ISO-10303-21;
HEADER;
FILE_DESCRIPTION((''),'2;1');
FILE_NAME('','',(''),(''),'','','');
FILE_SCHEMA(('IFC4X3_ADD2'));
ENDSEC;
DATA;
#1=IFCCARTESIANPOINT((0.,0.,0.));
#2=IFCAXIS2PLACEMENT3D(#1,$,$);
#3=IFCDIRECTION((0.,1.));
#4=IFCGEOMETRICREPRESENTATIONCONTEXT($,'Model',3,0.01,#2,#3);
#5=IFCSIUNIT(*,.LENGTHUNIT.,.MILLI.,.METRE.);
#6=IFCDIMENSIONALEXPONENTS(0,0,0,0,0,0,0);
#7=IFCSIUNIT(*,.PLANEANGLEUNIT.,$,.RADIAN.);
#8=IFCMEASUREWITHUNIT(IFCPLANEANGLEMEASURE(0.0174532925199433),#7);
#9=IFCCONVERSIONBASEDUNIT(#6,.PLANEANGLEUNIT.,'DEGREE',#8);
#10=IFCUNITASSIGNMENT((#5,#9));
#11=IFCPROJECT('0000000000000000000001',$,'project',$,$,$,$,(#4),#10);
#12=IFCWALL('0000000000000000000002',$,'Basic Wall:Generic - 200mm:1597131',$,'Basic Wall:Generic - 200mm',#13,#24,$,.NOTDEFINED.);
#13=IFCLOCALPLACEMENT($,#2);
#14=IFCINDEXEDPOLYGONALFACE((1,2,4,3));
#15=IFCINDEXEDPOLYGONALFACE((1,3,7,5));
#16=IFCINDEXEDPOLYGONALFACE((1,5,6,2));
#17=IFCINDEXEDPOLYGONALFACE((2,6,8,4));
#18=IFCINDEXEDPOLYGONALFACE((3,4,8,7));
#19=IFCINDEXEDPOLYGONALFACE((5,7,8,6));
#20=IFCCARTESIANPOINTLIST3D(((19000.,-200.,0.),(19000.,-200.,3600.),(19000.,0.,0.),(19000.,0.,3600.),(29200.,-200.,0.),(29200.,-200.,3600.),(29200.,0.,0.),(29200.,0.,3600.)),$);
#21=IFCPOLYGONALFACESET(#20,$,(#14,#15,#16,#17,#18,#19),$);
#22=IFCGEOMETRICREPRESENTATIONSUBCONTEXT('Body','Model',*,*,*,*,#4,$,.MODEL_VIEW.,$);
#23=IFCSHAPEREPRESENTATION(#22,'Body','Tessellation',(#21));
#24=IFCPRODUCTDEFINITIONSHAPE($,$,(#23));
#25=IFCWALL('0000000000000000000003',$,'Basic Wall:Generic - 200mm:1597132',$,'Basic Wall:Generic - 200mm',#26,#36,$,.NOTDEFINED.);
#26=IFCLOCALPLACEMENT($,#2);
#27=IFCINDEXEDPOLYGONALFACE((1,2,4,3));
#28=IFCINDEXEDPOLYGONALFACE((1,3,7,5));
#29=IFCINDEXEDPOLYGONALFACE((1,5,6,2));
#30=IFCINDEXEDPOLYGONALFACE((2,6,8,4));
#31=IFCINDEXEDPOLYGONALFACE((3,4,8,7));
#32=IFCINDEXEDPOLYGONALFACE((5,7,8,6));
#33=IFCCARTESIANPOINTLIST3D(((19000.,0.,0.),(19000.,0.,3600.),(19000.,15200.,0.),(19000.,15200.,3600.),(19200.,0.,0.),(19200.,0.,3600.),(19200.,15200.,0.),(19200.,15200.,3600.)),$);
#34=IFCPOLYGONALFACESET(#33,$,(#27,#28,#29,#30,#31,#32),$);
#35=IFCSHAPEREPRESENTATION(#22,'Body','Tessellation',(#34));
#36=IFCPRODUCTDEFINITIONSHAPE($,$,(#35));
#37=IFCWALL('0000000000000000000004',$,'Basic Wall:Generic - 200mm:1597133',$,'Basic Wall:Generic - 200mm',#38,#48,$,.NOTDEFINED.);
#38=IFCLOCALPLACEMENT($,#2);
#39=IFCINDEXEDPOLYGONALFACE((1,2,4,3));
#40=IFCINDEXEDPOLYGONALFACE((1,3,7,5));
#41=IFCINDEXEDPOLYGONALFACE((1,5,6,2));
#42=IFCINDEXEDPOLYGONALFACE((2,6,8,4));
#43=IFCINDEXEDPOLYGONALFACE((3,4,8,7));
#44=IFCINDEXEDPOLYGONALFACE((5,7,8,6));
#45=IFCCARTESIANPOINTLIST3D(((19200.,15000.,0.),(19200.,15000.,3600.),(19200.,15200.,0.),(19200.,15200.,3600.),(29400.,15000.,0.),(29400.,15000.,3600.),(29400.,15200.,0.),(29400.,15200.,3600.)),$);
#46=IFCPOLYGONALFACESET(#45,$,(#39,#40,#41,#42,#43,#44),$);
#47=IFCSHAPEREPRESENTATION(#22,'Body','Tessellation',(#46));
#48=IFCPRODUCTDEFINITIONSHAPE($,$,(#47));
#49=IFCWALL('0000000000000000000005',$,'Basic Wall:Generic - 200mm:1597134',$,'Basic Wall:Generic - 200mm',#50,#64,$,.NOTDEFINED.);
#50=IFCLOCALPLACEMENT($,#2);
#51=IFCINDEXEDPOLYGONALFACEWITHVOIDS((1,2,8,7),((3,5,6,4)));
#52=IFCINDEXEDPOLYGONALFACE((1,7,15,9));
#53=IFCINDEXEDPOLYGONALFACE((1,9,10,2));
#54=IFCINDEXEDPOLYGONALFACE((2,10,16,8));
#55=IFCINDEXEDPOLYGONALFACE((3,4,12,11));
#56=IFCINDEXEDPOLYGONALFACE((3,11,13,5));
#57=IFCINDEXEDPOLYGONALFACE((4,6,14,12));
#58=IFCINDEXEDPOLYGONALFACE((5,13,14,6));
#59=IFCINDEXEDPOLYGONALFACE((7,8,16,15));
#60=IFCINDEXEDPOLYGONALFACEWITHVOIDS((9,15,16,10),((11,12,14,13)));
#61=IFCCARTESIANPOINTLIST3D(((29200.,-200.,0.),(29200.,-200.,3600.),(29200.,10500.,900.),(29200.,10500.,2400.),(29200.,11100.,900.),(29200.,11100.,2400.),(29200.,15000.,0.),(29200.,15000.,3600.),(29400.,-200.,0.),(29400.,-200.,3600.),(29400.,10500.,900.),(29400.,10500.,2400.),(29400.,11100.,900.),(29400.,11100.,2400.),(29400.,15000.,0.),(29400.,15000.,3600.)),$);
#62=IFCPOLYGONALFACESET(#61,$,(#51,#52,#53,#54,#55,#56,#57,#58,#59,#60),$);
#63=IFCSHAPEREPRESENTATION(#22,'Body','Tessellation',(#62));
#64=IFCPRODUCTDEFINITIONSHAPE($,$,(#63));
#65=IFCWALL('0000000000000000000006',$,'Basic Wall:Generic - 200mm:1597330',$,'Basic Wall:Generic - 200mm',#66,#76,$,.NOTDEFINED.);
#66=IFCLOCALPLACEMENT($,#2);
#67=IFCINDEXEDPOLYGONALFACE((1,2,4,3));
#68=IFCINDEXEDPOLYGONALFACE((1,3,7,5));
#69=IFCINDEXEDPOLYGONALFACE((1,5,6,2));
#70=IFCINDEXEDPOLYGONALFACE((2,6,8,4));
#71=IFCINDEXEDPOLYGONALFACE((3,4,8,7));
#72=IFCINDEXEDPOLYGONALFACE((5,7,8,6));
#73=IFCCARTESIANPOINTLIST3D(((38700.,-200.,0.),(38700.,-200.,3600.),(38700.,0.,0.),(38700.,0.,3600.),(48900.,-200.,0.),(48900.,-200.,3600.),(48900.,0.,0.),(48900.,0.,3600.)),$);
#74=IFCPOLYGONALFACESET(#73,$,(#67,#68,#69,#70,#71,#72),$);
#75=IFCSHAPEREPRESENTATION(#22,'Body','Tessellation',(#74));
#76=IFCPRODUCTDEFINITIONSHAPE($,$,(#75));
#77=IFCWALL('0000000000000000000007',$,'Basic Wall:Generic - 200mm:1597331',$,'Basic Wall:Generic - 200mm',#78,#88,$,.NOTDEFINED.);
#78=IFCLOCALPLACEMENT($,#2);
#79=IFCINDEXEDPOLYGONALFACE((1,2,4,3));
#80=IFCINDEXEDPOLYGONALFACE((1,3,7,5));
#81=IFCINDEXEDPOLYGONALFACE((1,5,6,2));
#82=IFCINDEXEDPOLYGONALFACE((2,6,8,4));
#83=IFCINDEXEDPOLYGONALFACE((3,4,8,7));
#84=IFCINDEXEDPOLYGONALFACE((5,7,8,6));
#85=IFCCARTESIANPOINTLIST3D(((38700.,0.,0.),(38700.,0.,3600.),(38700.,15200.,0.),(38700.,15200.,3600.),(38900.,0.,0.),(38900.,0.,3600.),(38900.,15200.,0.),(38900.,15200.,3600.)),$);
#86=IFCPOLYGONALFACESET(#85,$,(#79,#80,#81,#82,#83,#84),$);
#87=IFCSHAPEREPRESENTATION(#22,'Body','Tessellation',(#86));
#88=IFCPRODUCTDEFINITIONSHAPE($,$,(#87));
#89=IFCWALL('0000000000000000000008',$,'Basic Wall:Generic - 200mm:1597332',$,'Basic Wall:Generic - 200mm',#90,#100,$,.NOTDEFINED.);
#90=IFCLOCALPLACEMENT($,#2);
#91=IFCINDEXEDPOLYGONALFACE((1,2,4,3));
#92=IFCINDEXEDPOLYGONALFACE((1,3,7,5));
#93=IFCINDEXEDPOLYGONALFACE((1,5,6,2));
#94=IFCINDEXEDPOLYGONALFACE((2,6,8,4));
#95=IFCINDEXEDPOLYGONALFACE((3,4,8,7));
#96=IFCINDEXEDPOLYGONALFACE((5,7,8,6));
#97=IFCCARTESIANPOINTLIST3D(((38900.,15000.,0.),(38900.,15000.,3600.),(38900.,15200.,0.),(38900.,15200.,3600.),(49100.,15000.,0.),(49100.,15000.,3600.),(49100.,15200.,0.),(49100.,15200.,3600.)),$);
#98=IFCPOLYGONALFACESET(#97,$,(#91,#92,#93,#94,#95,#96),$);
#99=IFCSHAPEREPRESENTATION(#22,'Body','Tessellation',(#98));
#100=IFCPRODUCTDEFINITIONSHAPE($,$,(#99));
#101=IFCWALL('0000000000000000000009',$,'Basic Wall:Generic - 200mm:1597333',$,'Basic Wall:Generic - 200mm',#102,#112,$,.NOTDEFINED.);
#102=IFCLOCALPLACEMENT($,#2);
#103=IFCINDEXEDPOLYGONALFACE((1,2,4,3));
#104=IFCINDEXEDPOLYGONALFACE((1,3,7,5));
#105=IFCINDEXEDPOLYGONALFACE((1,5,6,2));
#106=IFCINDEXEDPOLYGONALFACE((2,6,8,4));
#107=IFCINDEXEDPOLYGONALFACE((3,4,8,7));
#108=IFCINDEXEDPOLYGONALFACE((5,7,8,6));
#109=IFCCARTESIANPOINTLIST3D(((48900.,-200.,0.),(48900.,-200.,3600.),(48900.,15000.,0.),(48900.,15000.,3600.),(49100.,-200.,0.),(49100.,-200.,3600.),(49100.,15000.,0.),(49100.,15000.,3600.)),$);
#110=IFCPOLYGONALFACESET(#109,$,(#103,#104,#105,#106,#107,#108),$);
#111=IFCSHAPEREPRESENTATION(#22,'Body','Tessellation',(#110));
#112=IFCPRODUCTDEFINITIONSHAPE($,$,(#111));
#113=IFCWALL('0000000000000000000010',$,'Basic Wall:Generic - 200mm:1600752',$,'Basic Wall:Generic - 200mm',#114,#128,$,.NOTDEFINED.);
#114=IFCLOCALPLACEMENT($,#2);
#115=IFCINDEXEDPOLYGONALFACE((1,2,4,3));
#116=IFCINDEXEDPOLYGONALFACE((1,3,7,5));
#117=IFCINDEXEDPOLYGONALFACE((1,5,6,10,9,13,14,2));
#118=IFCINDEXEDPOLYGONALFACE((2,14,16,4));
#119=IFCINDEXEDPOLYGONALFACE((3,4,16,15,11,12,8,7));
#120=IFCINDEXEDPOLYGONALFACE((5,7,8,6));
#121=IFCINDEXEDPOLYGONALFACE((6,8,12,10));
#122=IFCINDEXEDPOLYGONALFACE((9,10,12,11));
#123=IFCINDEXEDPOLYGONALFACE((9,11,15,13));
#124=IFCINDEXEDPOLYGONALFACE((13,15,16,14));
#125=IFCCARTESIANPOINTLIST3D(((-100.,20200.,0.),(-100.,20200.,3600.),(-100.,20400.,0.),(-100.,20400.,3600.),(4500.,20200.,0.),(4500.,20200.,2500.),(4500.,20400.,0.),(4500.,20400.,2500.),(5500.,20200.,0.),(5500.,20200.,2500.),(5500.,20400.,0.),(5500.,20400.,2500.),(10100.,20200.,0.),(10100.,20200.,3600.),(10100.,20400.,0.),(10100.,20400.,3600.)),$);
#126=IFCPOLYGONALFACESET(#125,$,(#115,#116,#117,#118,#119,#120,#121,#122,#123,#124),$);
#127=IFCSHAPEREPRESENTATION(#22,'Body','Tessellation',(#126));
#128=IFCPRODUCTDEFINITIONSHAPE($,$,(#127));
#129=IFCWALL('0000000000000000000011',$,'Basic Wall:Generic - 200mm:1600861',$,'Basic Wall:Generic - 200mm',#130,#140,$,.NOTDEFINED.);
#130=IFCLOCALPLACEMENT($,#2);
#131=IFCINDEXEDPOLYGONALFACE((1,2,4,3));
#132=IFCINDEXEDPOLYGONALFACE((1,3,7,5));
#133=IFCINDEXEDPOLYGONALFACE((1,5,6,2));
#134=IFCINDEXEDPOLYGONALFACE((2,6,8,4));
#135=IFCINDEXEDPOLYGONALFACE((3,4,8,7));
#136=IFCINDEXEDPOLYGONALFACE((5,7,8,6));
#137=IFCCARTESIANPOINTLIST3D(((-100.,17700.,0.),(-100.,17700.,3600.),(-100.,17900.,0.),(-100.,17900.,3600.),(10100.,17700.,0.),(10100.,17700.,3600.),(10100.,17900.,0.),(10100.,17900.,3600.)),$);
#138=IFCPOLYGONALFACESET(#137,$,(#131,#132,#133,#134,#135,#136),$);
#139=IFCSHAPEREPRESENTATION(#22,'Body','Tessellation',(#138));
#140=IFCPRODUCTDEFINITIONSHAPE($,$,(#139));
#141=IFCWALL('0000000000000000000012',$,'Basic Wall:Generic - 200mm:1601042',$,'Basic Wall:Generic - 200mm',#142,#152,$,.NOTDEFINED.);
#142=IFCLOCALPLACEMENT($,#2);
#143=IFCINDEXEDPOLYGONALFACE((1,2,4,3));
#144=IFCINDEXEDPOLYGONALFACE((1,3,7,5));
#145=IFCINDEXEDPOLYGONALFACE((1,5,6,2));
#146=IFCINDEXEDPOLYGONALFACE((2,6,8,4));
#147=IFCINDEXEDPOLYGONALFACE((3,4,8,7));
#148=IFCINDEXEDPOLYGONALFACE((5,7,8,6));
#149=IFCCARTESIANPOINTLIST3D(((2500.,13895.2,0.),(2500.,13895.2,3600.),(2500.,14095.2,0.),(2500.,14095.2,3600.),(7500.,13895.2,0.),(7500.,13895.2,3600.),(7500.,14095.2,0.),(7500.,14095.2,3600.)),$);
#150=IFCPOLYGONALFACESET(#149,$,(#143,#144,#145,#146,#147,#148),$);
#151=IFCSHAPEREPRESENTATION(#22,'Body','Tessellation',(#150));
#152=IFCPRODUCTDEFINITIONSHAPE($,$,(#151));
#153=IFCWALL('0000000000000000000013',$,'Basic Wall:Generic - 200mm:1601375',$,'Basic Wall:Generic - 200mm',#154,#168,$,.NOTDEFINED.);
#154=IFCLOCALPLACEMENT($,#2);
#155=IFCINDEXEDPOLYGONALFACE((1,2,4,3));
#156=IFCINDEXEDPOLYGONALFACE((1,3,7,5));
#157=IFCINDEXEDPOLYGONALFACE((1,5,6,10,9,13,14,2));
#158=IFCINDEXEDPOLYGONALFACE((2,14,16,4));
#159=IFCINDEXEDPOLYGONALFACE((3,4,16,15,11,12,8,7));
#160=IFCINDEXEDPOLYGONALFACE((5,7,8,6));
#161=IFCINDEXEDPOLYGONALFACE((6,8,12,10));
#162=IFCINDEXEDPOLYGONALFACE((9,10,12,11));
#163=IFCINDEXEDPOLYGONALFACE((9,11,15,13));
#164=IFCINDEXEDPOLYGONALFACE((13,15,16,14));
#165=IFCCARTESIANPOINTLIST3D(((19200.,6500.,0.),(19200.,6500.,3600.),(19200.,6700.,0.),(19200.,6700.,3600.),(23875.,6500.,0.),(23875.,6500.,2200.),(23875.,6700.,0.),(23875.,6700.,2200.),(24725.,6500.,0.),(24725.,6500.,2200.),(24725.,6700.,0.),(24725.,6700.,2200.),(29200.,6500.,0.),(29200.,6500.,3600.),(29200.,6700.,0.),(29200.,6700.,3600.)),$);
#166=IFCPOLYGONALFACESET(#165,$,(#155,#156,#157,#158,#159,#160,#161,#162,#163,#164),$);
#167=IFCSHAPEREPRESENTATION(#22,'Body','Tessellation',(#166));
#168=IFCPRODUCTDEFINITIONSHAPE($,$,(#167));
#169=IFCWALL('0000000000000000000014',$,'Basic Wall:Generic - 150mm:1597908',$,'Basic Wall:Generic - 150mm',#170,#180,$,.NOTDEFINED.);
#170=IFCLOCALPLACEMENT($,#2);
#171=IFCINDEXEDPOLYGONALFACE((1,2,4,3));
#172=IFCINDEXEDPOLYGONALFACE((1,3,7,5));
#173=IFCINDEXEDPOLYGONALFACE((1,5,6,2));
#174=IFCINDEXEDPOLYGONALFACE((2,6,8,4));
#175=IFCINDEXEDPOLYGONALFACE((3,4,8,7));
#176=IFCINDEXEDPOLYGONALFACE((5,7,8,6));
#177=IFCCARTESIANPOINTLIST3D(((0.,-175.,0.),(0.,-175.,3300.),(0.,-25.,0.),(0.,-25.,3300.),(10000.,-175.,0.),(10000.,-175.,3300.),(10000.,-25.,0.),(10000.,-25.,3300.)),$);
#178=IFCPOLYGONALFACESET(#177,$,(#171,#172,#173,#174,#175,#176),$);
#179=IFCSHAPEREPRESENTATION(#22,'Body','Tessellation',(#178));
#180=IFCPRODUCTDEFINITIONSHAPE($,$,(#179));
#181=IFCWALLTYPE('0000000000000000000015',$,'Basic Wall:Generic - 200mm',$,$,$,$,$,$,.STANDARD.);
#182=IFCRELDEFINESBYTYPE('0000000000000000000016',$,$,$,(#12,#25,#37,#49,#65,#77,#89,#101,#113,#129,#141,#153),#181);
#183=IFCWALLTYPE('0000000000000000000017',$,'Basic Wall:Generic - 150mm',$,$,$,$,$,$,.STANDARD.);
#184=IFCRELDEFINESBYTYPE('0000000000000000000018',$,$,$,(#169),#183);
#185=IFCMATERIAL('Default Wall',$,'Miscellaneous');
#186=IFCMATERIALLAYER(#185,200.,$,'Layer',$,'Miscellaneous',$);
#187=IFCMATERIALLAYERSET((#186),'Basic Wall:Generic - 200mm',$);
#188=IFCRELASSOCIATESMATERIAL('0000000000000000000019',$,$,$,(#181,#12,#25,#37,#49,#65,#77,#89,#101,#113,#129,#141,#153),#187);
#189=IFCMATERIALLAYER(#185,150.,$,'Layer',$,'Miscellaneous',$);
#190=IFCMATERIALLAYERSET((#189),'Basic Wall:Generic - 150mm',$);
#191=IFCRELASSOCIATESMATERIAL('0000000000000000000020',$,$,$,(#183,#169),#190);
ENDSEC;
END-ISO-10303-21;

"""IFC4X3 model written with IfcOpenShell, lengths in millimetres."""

from ifc_helpers import new_model, entity, si_unit, converted_unit, direction, frame, frame_2d, origin, origin_2d_with_axis, place, context, subcontext, project, rectangle, extrude, material, layer, layer_set, type_object, element, save


model = new_model("IFC4X3")

# Units and contexts
model_context = context("Model", 3, precision=0.01, world=origin(), true_north=direction((0.0, 1.0)))
body_context = subcontext(model_context, "Body", "Model", "MODEL_VIEW")
ifc_project = project(units=[si_unit("LENGTHUNIT", "METRE", prefix="MILLI"), converted_unit("PLANEANGLEUNIT", "DEGREE", entity("IfcPlaneAngleMeasure", 0.0174532925199433), si_unit("PLANEANGLEUNIT", "RADIAN"), dimensions=[0, 0, 0, 0, 0, 0, 0])], contexts=[model_context])

# Shared definitions
placement_1 = place(None, origin())
placement_2 = place(placement_1, origin())
placement_3 = place(placement_2, origin())

# Walls
ifc_material_1 = material(Name="Default Wall", Category="Miscellaneous")
ifc_layer_1 = layer(ifc_material_1, 200.0, Name="Layer", Category="Miscellaneous")
ifc_layer_set_1 = layer_set([ifc_layer_1], Name="Basic Wall:Generic - 200mm")
wall_type_1 = type_object("IfcWallType", Name="Basic Wall:Generic - 200mm", PredefinedType="STANDARD", material=ifc_layer_set_1)
wall_1_placement = place(placement_3, frame((19000.0, -100.0, 0.0)))
element("IfcWall", 1, at=wall_1_placement, type_object=wall_type_1, material=ifc_layer_set_1, Name="Basic Wall:Generic - 200mm:1597131", ObjectType="Basic Wall:Generic - 200mm", PredefinedType="NOTDEFINED", context=body_context, shape_type="SweptSolid", body=[
    extrude(rectangle(XDim=10200.0, YDim=200.0, at=frame_2d((5100.0, 0.0), x_axis=(-1.0, 0.0))), origin(), (0.0, 0.0, 1.0), 3600.0),
])
wall_2_placement = place(placement_3, frame((19100.0, 15200.0, 0.0), z_axis=(0.0, 0.0, 1.0), x_axis=(0.0, -1.0, 0.0)))
element("IfcWall", 2, at=wall_2_placement, type_object=wall_type_1, material=ifc_layer_set_1, Name="Basic Wall:Generic - 200mm:1597132", ObjectType="Basic Wall:Generic - 200mm", PredefinedType="NOTDEFINED", context=body_context, shape_type="SweptSolid", body=[
    extrude(rectangle(XDim=15200.0, YDim=200.0, at=frame_2d((7600.0, 0.0), x_axis=(-1.0, 0.0))), origin(), (0.0, 0.0, 1.0), 3600.0),
])
wall_3_placement = place(placement_3, frame((29400.0, 15100.0, 0.0), z_axis=(0.0, 0.0, 1.0), x_axis=(-1.0, 0.0, 0.0)))
element("IfcWall", 3, at=wall_3_placement, type_object=wall_type_1, material=ifc_layer_set_1, Name="Basic Wall:Generic - 200mm:1597133", ObjectType="Basic Wall:Generic - 200mm", PredefinedType="NOTDEFINED", context=body_context, shape_type="SweptSolid", body=[
    extrude(rectangle(XDim=10200.0, YDim=200.0, at=frame_2d((5100.0, 0.0), x_axis=(-1.0, 0.0))), origin(), (0.0, 0.0, 1.0), 3600.0),
])

# Wall, opening
wall_4_placement = place(placement_3, frame((29300.0, -200.0, 0.0), z_axis=(0.0, 0.0, 1.0), x_axis=(0.0, 1.0, 0.0)))
wall_4 = element("IfcWall", 4, at=wall_4_placement, type_object=wall_type_1, material=ifc_layer_set_1, Name="Basic Wall:Generic - 200mm:1597134", ObjectType="Basic Wall:Generic - 200mm", PredefinedType="NOTDEFINED", context=body_context, shape_type="SweptSolid", body=[
    extrude(rectangle(XDim=15200.0, YDim=200.0, at=frame_2d((7600.0, 0.0), x_axis=(-1.0, 0.0))), origin(), (0.0, 0.0, 1.0), 3600.0),
])
opening_1_placement = place(wall_4_placement, frame((11300.0, 100.0, 900.0)))
element("IfcOpeningElement", 5, at=opening_1_placement, cuts=wall_4, PredefinedType="OPENING", context=body_context, shape_type="SweptSolid", body=[
    extrude(rectangle(XDim=1500.0, YDim=600.0, at=frame_2d((750.0, 300.0), x_axis=(-1.0, 0.0))), frame((0.0, 0.0, 0.0), z_axis=(0.0, -1.0, 0.0), x_axis=(0.0, 0.0, 1.0)), (0.0, 0.0, 1.0), 200.0),
])

# Walls
wall_5_placement = place(placement_3, frame((38700.0, -100.0, 0.0)))
element("IfcWall", 6, at=wall_5_placement, type_object=wall_type_1, material=ifc_layer_set_1, Name="Basic Wall:Generic - 200mm:1597330", ObjectType="Basic Wall:Generic - 200mm", PredefinedType="NOTDEFINED", context=body_context, shape_type="SweptSolid", body=[
    extrude(rectangle(XDim=10200.0, YDim=200.0, at=frame_2d((5100.0, 0.0), x_axis=(-1.0, 0.0))), origin(), (0.0, 0.0, 1.0), 3600.0),
])
wall_6_placement = place(placement_3, frame((38800.0, 15200.0, 0.0), z_axis=(0.0, 0.0, 1.0), x_axis=(0.0, -1.0, 0.0)))
element("IfcWall", 7, at=wall_6_placement, type_object=wall_type_1, material=ifc_layer_set_1, Name="Basic Wall:Generic - 200mm:1597331", ObjectType="Basic Wall:Generic - 200mm", PredefinedType="NOTDEFINED", context=body_context, shape_type="SweptSolid", body=[
    extrude(rectangle(XDim=15200.0, YDim=200.0, at=frame_2d((7600.0, 0.0), x_axis=(-1.0, 0.0))), origin(), (0.0, 0.0, 1.0), 3600.0),
])
wall_7_placement = place(placement_3, frame((49100.0, 15100.0, 0.0), z_axis=(0.0, 0.0, 1.0), x_axis=(-1.0, 0.0, 0.0)))
element("IfcWall", 8, at=wall_7_placement, type_object=wall_type_1, material=ifc_layer_set_1, Name="Basic Wall:Generic - 200mm:1597332", ObjectType="Basic Wall:Generic - 200mm", PredefinedType="NOTDEFINED", context=body_context, shape_type="SweptSolid", body=[
    extrude(rectangle(XDim=10200.0, YDim=200.0, at=frame_2d((5100.0, 0.0), x_axis=(-1.0, 0.0))), origin(), (0.0, 0.0, 1.0), 3600.0),
])
wall_8_placement = place(placement_3, frame((49000.0, -200.0, 0.0), z_axis=(0.0, 0.0, 1.0), x_axis=(0.0, 1.0, 0.0)))
element("IfcWall", 9, at=wall_8_placement, type_object=wall_type_1, material=ifc_layer_set_1, Name="Basic Wall:Generic - 200mm:1597333", ObjectType="Basic Wall:Generic - 200mm", PredefinedType="NOTDEFINED", context=body_context, shape_type="SweptSolid", body=[
    extrude(rectangle(XDim=15200.0, YDim=200.0, at=frame_2d((7600.0, 0.0), x_axis=(-1.0, 0.0))), origin(), (0.0, 0.0, 1.0), 3600.0),
])

# Wall, opening
wall_9_placement = place(placement_3, frame((10100.0, 20300.0, 0.0), z_axis=(0.0, 0.0, 1.0), x_axis=(-1.0, 0.0, 0.0)))
wall_9 = element("IfcWall", 10, at=wall_9_placement, type_object=wall_type_1, material=ifc_layer_set_1, Name="Basic Wall:Generic - 200mm:1600752", ObjectType="Basic Wall:Generic - 200mm", PredefinedType="NOTDEFINED", context=body_context, shape_type="SweptSolid", body=[
    extrude(rectangle(XDim=10200.0, YDim=200.0, at=frame_2d((5100.0, 0.0), x_axis=(1.0, 0.0))), origin(), (0.0, 0.0, 1.0), 3600.0),
])
opening_2_placement = place(wall_9_placement, frame((5600.0, 100.0, 0.0)))
element("IfcOpeningElement", 11, at=opening_2_placement, cuts=wall_9, PredefinedType="OPENING", context=body_context, shape_type="SweptSolid", body=[
    extrude(rectangle(XDim=2500.0, YDim=1000.0, at=origin_2d_with_axis()), frame((-500.0, -200.0, 1250.0), z_axis=(0.0, 1.0, 0.0), x_axis=(0.0, 0.0, -1.0)), (0.0, 0.0, 1.0), 200.0),
])

# Walls
wall_10_placement = place(placement_3, frame((10100.0, 17800.0, 0.0), z_axis=(0.0, 0.0, 1.0), x_axis=(-1.0, 0.0, 0.0)))
element("IfcWall", 12, at=wall_10_placement, type_object=wall_type_1, material=ifc_layer_set_1, Name="Basic Wall:Generic - 200mm:1600861", ObjectType="Basic Wall:Generic - 200mm", PredefinedType="NOTDEFINED", context=body_context, shape_type="SweptSolid", body=[
    extrude(rectangle(XDim=10200.0, YDim=200.0, at=frame_2d((5100.0, 0.0), x_axis=(-1.0, 0.0))), origin(), (0.0, 0.0, 1.0), 3600.0),
])
wall_11_placement = place(placement_3, frame((7500.0, 13995.2, 0.0), z_axis=(0.0, 0.0, 1.0), x_axis=(-1.0, 0.0, 0.0)))
element("IfcWall", 13, at=wall_11_placement, type_object=wall_type_1, material=ifc_layer_set_1, Name="Basic Wall:Generic - 200mm:1601042", ObjectType="Basic Wall:Generic - 200mm", PredefinedType="NOTDEFINED", context=body_context, shape_type="SweptSolid", body=[
    extrude(rectangle(XDim=5000.0, YDim=200.0, at=frame_2d((2500.0, 0.0), x_axis=(-1.0, 0.0))), origin(), (0.0, 0.0, 1.0), 3600.0),
])

# Wall, opening
wall_12_placement = place(placement_3, frame((29200.0, 6600.0, 0.0), z_axis=(0.0, 0.0, 1.0), x_axis=(-1.0, 0.0, 0.0)))
wall_12 = element("IfcWall", 14, at=wall_12_placement, type_object=wall_type_1, material=ifc_layer_set_1, Name="Basic Wall:Generic - 200mm:1601375", ObjectType="Basic Wall:Generic - 200mm", PredefinedType="NOTDEFINED", context=body_context, shape_type="SweptSolid", body=[
    extrude(rectangle(XDim=10000.0, YDim=200.0, at=frame_2d((5000.0, 0.0), x_axis=(1.0, 0.0))), origin(), (0.0, 0.0, 1.0), 3600.0),
])
opening_3_placement = place(wall_12_placement, frame((5325.0, 100.0, 0.0)))
element("IfcOpeningElement", 15, at=opening_3_placement, cuts=wall_12, PredefinedType="OPENING", context=body_context, shape_type="SweptSolid", body=[
    extrude(rectangle(XDim=2200.0, YDim=850.0, at=frame_2d((1100.0, 425.0), x_axis=(1.0, 0.0))), frame((0.0, 0.0, 0.0), z_axis=(0.0, -1.0, 0.0), x_axis=(0.0, 0.0, 1.0)), (0.0, 0.0, 1.0), 200.0),
])

# Wall
ifc_layer_2 = layer(ifc_material_1, 150.0, Name="Layer", Category="Miscellaneous")
ifc_layer_set_2 = layer_set([ifc_layer_2], Name="Basic Wall:Generic - 150mm")
wall_type_2 = type_object("IfcWallType", Name="Basic Wall:Generic - 150mm", PredefinedType="STANDARD", material=ifc_layer_set_2)
wall_13_placement = place(placement_3, frame((0.0, -100.0, 0.0)))
element("IfcWall", 16, at=wall_13_placement, type_object=wall_type_2, material=ifc_layer_set_2, Name="Basic Wall:Generic - 150mm:1597908", ObjectType="Basic Wall:Generic - 150mm", PredefinedType="NOTDEFINED", context=body_context, shape_type="SweptSolid", body=[
    extrude(rectangle(XDim=10000.0, YDim=150.0, at=frame_2d((5000.0, 0.0), x_axis=(-1.0, 0.0))), origin(), (0.0, 0.0, 1.0), 3300.0),
])

save(model, "model.ifc")
